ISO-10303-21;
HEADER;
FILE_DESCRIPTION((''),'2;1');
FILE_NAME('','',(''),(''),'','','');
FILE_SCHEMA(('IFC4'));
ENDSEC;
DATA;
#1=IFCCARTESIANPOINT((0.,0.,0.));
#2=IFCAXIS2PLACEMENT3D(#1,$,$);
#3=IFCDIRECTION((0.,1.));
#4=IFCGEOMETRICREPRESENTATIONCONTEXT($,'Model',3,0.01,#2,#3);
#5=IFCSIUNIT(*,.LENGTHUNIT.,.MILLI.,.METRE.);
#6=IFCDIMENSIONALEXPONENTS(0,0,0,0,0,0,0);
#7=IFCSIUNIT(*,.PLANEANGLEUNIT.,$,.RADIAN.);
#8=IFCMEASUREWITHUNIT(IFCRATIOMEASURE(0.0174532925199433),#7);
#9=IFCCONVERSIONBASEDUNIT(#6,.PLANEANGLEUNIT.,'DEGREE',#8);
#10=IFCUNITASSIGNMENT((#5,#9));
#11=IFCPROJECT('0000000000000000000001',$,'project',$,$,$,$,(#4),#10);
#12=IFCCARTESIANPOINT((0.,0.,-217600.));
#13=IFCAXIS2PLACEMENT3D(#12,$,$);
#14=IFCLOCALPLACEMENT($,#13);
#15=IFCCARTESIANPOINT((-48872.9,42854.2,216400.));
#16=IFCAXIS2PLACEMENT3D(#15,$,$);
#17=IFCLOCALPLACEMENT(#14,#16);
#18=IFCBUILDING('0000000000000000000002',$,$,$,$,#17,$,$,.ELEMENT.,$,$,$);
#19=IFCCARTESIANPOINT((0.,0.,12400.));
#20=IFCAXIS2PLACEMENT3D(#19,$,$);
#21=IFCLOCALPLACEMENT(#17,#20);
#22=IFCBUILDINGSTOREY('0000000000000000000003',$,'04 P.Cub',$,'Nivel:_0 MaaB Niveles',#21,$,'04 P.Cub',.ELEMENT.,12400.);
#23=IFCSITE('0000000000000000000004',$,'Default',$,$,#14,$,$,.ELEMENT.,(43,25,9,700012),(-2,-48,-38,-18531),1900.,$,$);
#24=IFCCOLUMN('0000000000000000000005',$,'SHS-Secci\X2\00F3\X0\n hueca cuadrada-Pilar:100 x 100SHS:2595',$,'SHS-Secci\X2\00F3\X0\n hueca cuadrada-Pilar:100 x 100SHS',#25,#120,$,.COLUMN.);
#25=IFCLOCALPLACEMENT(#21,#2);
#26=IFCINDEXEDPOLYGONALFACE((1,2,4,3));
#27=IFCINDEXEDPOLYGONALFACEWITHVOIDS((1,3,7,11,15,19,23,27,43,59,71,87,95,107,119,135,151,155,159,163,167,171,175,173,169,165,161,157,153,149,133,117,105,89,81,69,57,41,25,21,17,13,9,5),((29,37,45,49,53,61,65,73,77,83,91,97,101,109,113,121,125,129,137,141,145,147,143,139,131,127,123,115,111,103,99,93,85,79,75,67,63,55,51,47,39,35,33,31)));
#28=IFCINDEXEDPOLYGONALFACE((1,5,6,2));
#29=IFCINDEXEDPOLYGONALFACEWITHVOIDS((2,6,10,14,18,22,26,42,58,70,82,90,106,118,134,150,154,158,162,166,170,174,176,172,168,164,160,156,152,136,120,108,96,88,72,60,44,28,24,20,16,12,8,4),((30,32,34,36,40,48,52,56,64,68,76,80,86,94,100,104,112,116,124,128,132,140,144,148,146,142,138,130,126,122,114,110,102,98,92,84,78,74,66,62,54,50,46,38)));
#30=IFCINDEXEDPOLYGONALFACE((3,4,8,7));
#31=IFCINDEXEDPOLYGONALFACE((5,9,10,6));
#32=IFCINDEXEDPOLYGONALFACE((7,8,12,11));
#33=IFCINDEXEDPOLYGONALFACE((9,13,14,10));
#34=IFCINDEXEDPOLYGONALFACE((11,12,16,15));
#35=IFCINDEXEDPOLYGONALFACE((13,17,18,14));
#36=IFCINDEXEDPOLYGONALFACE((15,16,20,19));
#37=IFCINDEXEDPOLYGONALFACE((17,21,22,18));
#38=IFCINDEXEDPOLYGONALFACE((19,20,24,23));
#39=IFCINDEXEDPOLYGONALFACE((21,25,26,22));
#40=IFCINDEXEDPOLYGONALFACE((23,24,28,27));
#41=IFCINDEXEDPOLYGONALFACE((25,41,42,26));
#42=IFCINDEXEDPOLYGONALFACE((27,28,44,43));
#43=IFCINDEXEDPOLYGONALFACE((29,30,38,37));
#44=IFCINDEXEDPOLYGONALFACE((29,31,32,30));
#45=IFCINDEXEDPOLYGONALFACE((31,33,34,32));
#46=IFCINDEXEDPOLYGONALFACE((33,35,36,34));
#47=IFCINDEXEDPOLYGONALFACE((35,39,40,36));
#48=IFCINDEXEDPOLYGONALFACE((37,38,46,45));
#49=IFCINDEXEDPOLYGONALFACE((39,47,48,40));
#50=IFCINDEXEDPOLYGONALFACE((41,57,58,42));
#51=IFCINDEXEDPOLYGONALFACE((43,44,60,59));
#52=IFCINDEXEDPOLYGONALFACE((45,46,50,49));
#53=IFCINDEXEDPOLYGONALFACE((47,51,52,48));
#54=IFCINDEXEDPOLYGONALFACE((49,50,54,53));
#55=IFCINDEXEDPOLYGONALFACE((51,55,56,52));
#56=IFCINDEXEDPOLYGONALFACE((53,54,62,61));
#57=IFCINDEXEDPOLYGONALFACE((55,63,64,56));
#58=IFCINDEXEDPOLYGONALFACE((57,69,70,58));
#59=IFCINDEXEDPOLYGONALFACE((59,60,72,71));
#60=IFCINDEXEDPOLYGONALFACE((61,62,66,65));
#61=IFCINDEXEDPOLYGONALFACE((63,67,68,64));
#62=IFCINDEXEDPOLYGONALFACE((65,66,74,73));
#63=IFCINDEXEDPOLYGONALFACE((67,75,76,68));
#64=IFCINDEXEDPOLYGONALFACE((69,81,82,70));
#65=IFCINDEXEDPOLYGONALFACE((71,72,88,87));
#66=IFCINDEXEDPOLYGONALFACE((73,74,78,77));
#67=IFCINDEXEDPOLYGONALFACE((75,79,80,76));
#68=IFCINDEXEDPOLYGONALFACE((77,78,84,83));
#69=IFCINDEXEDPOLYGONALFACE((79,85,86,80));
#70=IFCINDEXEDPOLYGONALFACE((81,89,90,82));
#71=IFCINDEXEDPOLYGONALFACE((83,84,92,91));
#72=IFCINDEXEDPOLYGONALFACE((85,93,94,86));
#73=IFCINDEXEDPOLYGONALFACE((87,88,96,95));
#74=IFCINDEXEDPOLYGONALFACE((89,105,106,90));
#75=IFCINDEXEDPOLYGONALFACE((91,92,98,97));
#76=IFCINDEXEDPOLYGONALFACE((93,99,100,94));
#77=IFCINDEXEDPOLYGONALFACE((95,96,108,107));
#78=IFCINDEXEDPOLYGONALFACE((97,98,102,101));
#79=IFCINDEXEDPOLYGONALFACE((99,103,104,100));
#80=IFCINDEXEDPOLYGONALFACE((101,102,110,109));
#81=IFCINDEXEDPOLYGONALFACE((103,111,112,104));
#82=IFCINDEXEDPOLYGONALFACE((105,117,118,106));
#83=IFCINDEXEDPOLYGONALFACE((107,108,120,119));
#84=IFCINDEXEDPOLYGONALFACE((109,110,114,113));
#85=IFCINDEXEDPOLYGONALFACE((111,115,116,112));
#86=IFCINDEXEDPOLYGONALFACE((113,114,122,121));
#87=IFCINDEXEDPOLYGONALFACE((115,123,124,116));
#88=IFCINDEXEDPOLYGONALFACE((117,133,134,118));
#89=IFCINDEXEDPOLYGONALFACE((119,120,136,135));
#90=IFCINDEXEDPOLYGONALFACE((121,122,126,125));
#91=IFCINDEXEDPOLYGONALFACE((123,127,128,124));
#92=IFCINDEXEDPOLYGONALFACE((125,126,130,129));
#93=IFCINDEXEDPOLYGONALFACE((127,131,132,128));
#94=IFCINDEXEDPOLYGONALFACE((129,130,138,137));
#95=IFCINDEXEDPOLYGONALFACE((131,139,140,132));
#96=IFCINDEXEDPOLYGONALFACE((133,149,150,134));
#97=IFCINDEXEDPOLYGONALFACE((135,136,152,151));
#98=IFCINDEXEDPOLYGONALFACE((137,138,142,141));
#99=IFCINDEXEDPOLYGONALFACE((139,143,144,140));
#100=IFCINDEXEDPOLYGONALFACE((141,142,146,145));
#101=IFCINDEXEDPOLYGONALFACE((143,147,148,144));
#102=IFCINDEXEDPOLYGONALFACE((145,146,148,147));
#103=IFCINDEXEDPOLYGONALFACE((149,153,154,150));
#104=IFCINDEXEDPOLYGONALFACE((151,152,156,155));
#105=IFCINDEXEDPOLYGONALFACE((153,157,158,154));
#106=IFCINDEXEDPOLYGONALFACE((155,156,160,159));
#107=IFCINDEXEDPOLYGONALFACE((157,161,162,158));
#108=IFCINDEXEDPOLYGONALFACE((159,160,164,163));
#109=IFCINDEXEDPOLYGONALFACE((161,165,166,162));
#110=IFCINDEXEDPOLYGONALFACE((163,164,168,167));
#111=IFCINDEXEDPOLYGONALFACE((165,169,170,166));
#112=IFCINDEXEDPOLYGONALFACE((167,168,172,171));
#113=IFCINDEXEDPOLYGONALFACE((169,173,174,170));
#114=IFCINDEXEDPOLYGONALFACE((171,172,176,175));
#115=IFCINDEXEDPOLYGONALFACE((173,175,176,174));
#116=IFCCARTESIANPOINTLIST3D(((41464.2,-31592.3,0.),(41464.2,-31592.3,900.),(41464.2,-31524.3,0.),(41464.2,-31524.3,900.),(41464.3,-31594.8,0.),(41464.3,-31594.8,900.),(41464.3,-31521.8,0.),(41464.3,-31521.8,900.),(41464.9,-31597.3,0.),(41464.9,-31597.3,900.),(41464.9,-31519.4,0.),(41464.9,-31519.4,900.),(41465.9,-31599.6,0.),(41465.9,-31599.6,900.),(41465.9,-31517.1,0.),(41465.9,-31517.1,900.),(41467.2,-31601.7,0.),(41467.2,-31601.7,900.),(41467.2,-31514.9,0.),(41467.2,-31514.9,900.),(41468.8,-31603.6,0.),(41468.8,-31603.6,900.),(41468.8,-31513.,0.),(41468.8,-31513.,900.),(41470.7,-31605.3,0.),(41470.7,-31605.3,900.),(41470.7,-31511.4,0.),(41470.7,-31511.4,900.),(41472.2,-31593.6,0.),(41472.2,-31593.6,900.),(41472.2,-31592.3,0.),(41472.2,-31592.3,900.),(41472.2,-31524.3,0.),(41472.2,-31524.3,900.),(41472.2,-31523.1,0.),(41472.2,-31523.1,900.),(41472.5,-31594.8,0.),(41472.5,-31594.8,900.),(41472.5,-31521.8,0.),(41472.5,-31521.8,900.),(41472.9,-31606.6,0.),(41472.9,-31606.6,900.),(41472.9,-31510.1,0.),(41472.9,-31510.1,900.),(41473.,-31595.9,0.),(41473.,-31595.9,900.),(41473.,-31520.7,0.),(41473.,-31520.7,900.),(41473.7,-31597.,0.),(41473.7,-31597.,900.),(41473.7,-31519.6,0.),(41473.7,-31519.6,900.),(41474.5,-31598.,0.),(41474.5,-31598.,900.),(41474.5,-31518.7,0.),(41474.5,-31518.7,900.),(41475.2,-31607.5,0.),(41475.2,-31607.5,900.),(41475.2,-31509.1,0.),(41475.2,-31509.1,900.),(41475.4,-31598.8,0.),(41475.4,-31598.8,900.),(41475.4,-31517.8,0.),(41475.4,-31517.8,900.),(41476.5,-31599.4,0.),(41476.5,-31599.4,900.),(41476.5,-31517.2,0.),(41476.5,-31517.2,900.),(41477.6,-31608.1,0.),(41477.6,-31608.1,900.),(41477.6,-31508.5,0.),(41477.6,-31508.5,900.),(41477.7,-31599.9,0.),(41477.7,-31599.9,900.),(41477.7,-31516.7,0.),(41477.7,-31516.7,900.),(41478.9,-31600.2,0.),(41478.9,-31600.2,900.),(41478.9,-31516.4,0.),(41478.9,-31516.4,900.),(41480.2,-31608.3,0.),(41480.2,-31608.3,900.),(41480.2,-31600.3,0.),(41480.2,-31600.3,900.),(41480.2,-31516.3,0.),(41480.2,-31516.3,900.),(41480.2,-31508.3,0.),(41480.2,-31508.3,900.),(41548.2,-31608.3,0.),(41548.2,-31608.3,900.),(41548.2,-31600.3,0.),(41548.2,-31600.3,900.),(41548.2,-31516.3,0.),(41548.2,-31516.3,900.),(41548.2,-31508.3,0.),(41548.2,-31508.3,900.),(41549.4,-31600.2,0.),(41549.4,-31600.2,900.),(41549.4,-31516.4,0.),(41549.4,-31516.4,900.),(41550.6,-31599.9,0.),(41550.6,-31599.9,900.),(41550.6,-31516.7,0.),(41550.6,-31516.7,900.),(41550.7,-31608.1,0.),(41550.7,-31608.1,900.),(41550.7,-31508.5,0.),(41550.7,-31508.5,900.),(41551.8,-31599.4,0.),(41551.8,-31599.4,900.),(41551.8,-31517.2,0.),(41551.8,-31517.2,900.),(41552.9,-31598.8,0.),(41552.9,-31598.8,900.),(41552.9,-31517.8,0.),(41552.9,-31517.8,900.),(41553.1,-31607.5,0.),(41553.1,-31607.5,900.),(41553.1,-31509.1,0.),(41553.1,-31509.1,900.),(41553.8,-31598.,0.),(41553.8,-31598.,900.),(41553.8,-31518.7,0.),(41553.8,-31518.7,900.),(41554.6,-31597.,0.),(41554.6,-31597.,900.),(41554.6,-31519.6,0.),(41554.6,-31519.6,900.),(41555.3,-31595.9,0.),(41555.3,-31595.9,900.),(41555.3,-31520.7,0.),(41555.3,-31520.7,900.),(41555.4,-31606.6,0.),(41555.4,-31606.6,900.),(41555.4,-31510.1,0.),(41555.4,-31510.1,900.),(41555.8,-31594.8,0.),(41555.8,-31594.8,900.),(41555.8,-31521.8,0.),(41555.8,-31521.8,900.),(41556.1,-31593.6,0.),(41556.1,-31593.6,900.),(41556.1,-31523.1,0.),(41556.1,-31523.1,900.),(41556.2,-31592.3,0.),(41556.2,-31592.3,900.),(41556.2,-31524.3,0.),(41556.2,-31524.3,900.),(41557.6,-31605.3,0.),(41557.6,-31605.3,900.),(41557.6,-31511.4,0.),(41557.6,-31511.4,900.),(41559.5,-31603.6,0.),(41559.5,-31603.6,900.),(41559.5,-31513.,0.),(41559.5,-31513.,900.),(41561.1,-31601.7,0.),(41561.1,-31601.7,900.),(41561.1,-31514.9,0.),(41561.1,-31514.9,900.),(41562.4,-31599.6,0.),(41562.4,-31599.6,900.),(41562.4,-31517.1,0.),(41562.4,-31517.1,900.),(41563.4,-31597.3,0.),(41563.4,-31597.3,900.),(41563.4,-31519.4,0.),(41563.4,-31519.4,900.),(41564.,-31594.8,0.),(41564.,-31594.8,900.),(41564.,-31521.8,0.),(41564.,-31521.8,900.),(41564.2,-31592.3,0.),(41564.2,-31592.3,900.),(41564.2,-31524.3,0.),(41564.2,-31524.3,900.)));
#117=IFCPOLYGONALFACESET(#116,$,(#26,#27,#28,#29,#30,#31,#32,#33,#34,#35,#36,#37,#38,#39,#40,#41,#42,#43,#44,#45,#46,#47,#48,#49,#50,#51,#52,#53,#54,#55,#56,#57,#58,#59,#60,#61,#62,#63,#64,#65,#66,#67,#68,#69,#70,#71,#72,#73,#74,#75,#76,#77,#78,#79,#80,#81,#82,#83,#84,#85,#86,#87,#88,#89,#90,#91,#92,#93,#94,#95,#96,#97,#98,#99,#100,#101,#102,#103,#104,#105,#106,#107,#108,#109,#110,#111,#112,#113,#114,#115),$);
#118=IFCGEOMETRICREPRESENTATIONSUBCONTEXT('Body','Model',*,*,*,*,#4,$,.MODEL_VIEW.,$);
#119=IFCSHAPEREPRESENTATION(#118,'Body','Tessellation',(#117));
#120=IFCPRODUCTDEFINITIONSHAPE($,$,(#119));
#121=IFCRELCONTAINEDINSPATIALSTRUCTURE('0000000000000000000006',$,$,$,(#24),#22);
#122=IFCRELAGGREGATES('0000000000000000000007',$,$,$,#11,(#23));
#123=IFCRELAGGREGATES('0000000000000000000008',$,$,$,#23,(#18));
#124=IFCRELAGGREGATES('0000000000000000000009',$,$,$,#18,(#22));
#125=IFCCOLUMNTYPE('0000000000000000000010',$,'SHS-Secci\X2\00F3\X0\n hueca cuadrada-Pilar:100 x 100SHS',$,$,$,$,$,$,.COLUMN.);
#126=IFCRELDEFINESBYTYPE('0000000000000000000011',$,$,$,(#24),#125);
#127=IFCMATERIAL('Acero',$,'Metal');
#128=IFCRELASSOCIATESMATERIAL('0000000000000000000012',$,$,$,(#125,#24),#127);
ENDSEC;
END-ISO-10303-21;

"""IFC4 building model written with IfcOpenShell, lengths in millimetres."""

from ifc_helpers import new_model, entity, si_unit, converted_unit, direction, frame, origin, place, context, subcontext, project, spatial, indexed_curve, outline, extrude, source, transform, mapped, material, type_object, type_shapes, element, save


model = new_model("IFC4")

# Units and contexts
model_context = context("Model", 3, precision=0.01, world=origin(), true_north=direction((0.0, 1.0)))
body_context = subcontext(model_context, "Body", "Model", "MODEL_VIEW")
ifc_project = project(units=[si_unit("LENGTHUNIT", "METRE", prefix="MILLI"), converted_unit("PLANEANGLEUNIT", "DEGREE", entity("IfcRatioMeasure", 0.0174532925199433), si_unit("PLANEANGLEUNIT", "RADIAN"), dimensions=[0, 0, 0, 0, 0, 0, 0])], contexts=[model_context])

# Site, building, storey
site_placement = place(None, frame((0.0, 0.0, -217600.0)))
site = spatial("IfcSite", under=ifc_project, at=site_placement, Name="Default", CompositionType="ELEMENT", RefLatitude=(43, 25, 9, 700012), RefLongitude=(-2, -48, -38, -18531), RefElevation=1900.0)
building_placement = place(site_placement, frame((-48872.9, 42854.2, 216400.0)))
building = spatial("IfcBuilding", under=site, at=building_placement, CompositionType="ELEMENT")
storey_placement = place(building_placement, frame((0.0, 0.0, 12400.0)))
storey = spatial("IfcBuildingStorey", under=building, at=storey_placement, Name="04 P.Cub", ObjectType="Nivel:_0 MaaB Niveles", LongName="04 P.Cub", CompositionType="ELEMENT", Elevation=12400.0)

# Column
ifc_material_1 = material(Name="Acero", Category="Metal")
column_type_1 = type_object("IfcColumnType", Name="SHS-Sección hueca cuadrada-Pilar:100 x 100SHS", PredefinedType="COLUMN", material=ifc_material_1)
shared_shape_1 = source(origin(), body_context, "Body", "SweptSolid", [
    extrude(outline(indexed_curve([(-34.0, -50.0), (34.0, -50.0), (36.5, -49.8), (38.9, -49.2), (41.3, -48.3), (43.4, -46.9), (45.3, -45.3), (46.9, -43.4), (48.3, -41.3), (49.2, -38.9), (49.8, -36.5), (50.0, -34.0), (50.0, 34.0), (49.8, 36.5), (49.2, 38.9), (48.3, 41.3), (46.9, 43.4), (45.3, 45.3), (43.4, 46.9), (41.3, 48.3), (38.9, 49.2), (36.5, 49.8), (34.0, 50.0), (-34.0, 50.0), (-36.5, 49.8), (-38.9, 49.2), (-41.3, 48.3), (-43.4, 46.9), (-45.3, 45.3), (-46.9, 43.4), (-48.3, 41.3), (-49.2, 38.9), (-49.8, 36.5), (-50.0, 34.0), (-50.0, -34.0), (-49.8, -36.5), (-49.2, -38.9), (-48.3, -41.3), (-46.9, -43.4), (-45.3, -45.3), (-43.4, -46.9), (-41.3, -48.3), (-38.9, -49.2), (-36.5, -49.8), (-34.0, -50.0)], self_intersect=False), holes=[indexed_curve([(-42.0, 34.0), (-41.9, 35.3), (-41.6, 36.5), (-41.1, 37.6), (-40.5, 38.7), (-39.7, 39.7), (-38.7, 40.5), (-37.6, 41.1), (-36.5, 41.6), (-35.3, 41.9), (-34.0, 42.0), (34.0, 42.0), (35.3, 41.9), (36.5, 41.6), (37.6, 41.1), (38.7, 40.5), (39.7, 39.7), (40.5, 38.7), (41.1, 37.6), (41.6, 36.5), (41.9, 35.3), (42.0, 34.0), (42.0, -34.0), (41.9, -35.3), (41.6, -36.5), (41.1, -37.6), (40.5, -38.7), (39.7, -39.7), (38.7, -40.5), (37.6, -41.1), (36.5, -41.6), (35.3, -41.9), (34.0, -42.0), (-34.0, -42.0), (-35.3, -41.9), (-36.5, -41.6), (-37.6, -41.1), (-38.7, -40.5), (-39.7, -39.7), (-40.5, -38.7), (-41.1, -37.6), (-41.6, -36.5), (-41.9, -35.3), (-42.0, -34.0), (-42.0, 34.0)], self_intersect=False)]), frame((0.0, 0.0, 12400.0), z_axis=(0.0, 0.0, 1.0), x_axis=(0.0, 1.0, 0.0)), (0.0, 0.0, 1.0), 900.0),
])
type_shapes(column_type_1, [shared_shape_1])
column_1_placement = place(storey_placement, frame((41514.2, -31558.3, -12400.0), z_axis=(0.0, 0.0, 1.0), x_axis=(0.0, -1.0, 0.0)))
element("IfcColumn", 1, at=column_1_placement, inside=storey, type_object=column_type_1, material=ifc_material_1, Name="SHS-Sección hueca cuadrada-Pilar:100 x 100SHS:2595", ObjectType="SHS-Sección hueca cuadrada-Pilar:100 x 100SHS", PredefinedType="COLUMN", context=body_context, shape_type="MappedRepresentation", body=[
    mapped(shared_shape_1, transform((0.0, 0.0, 0.0), scale=1.0)),
])

save(model, "model.ifc")
